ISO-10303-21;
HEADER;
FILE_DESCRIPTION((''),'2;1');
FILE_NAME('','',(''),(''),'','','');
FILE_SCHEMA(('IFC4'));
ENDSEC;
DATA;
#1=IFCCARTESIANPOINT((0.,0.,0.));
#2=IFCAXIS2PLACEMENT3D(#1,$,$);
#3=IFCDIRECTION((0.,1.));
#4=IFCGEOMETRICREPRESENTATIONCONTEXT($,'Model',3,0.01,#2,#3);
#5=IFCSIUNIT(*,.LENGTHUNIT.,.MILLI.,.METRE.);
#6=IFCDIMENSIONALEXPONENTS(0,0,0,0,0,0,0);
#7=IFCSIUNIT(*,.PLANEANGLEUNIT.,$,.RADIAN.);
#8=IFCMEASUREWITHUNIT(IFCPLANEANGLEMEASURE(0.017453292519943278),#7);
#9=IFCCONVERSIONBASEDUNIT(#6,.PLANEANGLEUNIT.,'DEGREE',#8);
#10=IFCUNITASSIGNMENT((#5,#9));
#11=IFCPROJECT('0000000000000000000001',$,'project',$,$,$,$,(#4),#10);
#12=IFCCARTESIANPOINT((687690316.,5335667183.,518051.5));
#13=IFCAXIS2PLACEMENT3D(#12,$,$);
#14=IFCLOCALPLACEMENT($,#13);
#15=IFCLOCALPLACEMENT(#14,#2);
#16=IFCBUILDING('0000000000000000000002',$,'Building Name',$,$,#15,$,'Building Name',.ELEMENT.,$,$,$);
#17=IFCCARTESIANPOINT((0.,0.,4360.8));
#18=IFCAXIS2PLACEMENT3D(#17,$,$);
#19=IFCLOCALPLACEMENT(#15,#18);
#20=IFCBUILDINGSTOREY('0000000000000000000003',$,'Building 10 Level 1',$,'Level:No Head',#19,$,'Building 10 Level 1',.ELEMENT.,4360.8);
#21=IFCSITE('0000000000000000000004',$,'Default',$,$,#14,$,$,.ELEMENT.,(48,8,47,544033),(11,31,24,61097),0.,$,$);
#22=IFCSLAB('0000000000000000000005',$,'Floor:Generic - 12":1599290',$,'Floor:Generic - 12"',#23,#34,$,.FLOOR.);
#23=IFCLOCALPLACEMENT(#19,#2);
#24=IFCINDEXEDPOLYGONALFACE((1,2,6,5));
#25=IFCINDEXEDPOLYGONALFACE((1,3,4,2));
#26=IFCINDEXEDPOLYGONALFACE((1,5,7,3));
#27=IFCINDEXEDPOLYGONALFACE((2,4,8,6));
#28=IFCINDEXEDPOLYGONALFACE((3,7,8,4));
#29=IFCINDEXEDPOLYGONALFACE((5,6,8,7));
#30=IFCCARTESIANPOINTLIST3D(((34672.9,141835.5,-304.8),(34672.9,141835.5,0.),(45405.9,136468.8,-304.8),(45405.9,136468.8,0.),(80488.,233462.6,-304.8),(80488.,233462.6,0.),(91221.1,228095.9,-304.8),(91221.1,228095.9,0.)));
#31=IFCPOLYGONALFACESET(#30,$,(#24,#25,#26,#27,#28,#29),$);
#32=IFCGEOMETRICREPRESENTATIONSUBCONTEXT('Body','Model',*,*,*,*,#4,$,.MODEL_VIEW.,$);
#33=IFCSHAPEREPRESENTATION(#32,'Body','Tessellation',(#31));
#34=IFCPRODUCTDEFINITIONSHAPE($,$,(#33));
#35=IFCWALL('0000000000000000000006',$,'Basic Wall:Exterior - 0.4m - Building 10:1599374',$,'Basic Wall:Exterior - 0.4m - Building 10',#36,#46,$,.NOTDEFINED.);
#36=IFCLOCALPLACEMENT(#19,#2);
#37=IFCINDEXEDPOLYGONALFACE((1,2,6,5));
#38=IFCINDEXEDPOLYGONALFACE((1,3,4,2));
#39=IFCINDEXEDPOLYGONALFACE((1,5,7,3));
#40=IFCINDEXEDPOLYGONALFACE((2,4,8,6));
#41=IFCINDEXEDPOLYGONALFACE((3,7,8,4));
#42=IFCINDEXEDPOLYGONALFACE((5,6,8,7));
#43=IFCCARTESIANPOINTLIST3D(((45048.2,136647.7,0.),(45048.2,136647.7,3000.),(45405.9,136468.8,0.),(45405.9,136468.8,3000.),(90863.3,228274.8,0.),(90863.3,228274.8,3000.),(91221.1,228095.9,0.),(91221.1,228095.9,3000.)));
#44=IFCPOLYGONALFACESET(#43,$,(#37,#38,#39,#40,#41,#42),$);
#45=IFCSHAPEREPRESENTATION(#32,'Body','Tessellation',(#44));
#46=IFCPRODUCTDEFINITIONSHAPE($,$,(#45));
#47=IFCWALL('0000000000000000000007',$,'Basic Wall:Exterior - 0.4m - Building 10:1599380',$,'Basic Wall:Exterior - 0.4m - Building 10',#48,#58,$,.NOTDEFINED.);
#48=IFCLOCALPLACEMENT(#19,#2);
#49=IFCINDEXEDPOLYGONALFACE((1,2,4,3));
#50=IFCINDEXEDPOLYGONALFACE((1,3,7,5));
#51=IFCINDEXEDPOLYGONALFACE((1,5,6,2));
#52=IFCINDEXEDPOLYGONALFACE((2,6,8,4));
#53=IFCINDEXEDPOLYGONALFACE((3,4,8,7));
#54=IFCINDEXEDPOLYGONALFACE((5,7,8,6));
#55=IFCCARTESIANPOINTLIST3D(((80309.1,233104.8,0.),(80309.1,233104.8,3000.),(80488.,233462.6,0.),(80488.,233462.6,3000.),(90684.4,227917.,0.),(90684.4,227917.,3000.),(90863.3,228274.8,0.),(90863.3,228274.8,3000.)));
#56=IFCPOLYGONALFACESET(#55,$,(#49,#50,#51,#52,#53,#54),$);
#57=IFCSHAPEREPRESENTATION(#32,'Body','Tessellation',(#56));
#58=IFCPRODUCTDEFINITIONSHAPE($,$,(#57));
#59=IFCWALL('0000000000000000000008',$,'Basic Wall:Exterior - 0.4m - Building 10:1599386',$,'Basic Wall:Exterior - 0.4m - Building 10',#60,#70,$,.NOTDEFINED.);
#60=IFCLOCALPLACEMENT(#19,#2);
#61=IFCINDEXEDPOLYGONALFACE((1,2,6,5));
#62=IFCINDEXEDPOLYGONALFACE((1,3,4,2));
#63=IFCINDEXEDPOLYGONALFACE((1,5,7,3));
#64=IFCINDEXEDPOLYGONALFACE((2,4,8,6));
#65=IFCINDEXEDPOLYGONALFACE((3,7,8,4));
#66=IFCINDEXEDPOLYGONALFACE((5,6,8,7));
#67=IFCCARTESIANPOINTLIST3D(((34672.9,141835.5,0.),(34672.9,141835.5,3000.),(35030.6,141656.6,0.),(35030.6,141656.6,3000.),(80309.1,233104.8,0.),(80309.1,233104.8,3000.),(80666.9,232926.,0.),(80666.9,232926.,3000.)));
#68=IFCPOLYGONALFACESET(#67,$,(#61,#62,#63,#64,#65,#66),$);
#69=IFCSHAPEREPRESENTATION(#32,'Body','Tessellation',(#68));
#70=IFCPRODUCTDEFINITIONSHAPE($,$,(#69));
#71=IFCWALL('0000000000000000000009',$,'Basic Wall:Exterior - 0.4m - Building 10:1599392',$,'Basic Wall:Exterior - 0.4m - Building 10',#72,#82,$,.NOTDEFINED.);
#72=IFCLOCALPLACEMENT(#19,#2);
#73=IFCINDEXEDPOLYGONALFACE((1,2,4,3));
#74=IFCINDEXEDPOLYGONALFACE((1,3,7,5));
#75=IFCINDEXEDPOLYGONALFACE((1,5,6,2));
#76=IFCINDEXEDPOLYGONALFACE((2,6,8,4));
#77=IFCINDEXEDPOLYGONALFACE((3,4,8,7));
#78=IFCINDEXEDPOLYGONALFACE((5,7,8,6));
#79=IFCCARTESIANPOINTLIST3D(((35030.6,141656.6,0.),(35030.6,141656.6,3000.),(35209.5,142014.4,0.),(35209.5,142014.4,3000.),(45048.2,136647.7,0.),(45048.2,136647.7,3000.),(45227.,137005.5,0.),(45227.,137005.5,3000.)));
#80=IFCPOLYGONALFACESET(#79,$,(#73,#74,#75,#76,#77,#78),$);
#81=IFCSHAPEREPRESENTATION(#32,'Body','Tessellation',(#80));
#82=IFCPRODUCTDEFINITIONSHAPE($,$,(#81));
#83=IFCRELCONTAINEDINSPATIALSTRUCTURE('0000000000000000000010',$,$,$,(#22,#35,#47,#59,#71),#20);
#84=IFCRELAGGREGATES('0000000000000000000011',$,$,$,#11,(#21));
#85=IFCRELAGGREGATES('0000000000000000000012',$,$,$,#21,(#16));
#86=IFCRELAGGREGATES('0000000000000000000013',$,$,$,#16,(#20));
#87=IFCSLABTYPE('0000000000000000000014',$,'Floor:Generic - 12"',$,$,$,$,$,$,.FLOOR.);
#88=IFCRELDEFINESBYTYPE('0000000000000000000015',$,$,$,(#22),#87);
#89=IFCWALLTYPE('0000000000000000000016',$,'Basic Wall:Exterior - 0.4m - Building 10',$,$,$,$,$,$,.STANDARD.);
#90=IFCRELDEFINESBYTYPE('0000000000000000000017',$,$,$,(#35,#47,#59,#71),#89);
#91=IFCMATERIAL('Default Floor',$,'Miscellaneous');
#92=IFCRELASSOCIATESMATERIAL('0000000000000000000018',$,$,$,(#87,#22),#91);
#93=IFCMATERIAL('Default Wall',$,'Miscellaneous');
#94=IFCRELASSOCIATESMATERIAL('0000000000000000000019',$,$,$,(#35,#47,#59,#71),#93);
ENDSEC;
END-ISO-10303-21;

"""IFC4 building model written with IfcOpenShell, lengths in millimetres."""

from ifc_helpers import new_model, entity, si_unit, converted_unit, direction, frame, origin, place, context, subcontext, project, spatial, indexed_curve, outline, extrude, material, type_object, element, save


model = new_model("IFC4")

# Units and contexts
model_context = context("Model", 3, precision=0.01, world=origin(), true_north=direction((0.0, 1.0)))
body_context = subcontext(model_context, "Body", "Model", "MODEL_VIEW")
ifc_project = project(units=[si_unit("LENGTHUNIT", "METRE", prefix="MILLI"), converted_unit("PLANEANGLEUNIT", "DEGREE", entity("IfcPlaneAngleMeasure", 0.017453292519943278), si_unit("PLANEANGLEUNIT", "RADIAN"), dimensions=[0, 0, 0, 0, 0, 0, 0])], contexts=[model_context])

# Site, building, storey
site_placement = place(None, frame((687690316.0, 5335667183.0, 518051.5)))
site = spatial("IfcSite", under=ifc_project, at=site_placement, Name="Default", CompositionType="ELEMENT", RefLatitude=(48, 8, 47, 544033), RefLongitude=(11, 31, 24, 61097), RefElevation=0.0)
building_placement = place(site_placement, origin())
building = spatial("IfcBuilding", under=site, at=building_placement, Name="Building Name", LongName="Building Name", CompositionType="ELEMENT")
storey_placement = place(building_placement, frame((0.0, 0.0, 4360.8)))
storey = spatial("IfcBuildingStorey", under=building, at=storey_placement, Name="Building 10 Level 1", ObjectType="Level:No Head", LongName="Building 10 Level 1", CompositionType="ELEMENT", Elevation=4360.8)

# Slab
ifc_material_1 = material(Name="Default Floor", Category="Miscellaneous")
slab_type = type_object("IfcSlabType", Name="Floor:Generic - 12\"", PredefinedType="FLOOR", material=ifc_material_1)
slab_placement = place(storey_placement, origin())
element("IfcSlab", 1, at=slab_placement, inside=storey, type_object=slab_type, material=ifc_material_1, Name="Floor:Generic - 12\":1599290", ObjectType="Floor:Generic - 12\"", PredefinedType="FLOOR", context=body_context, shape_type="SweptSolid", body=[
    extrude(outline(indexed_curve([(-51221.4, -6000.0), (51221.4, -6000.0), (51221.4, 6000.0), (-51221.4, 6000.0), (-51221.4, -6000.0)], self_intersect=False)), frame((62947.0, 184965.7, 0.0), z_axis=(0.0, 0.0, -1.0), x_axis=(-0.447226, -0.894421, 0.0)), (0.0, 0.0, 1.0), 304.8),
])

# Walls
ifc_material_2 = material(Name="Default Wall", Category="Miscellaneous")
wall_type = type_object("IfcWallType", Name="Basic Wall:Exterior - 0.4m - Building 10", PredefinedType="STANDARD")
wall_1_placement = place(storey_placement, frame((45227.0, 136558.3, 0.0), z_axis=(0.0, 0.0, 1.0), x_axis=(0.447226, 0.894421, 0.0)))
element("IfcWall", 2, at=wall_1_placement, inside=storey, type_object=wall_type, material=ifc_material_2, Name="Basic Wall:Exterior - 0.4m - Building 10:1599374", ObjectType="Basic Wall:Exterior - 0.4m - Building 10", PredefinedType="NOTDEFINED", context=body_context, shape_type="SweptSolid", body=[
    extrude(outline(indexed_curve([(102442.9, 200.0), (0.0, 200.0), (0.0, -200.0), (102442.9, -200.0), (102442.9, 200.0)], self_intersect=False)), origin(), (0.0, 0.0, 1.0), 3000.0),
])
wall_2_placement = place(storey_placement, frame((90773.8, 228095.9, 0.0), z_axis=(0.0, 0.0, 1.0), x_axis=(-0.894421, 0.447226, 0.0)))
element("IfcWall", 3, at=wall_2_placement, inside=storey, type_object=wall_type, material=ifc_material_2, Name="Basic Wall:Exterior - 0.4m - Building 10:1599380", ObjectType="Basic Wall:Exterior - 0.4m - Building 10", PredefinedType="NOTDEFINED", context=body_context, shape_type="SweptSolid", body=[
    extrude(outline(indexed_curve([(11600.0, 200.0), (0.0, 200.0), (0.0, -200.0), (11600.0, -200.0), (11600.0, 200.0)], self_intersect=False)), origin(), (0.0, 0.0, 1.0), 3000.0),
])
wall_3_placement = place(storey_placement, frame((80488.0, 233015.4, 0.0), z_axis=(0.0, 0.0, 1.0), x_axis=(-0.447226, -0.894421, 0.0)))
element("IfcWall", 4, at=wall_3_placement, inside=storey, type_object=wall_type, material=ifc_material_2, Name="Basic Wall:Exterior - 0.4m - Building 10:1599386", ObjectType="Basic Wall:Exterior - 0.4m - Building 10", PredefinedType="NOTDEFINED", context=body_context, shape_type="SweptSolid", body=[
    extrude(outline(indexed_curve([(102042.9, 200.0), (0.0, 200.0), (0.0, -200.0), (102042.9, -200.0), (102042.9, 200.0)], self_intersect=False)), origin(), (0.0, 0.0, 1.0), 3000.0),
])
wall_4_placement = place(storey_placement, frame((35120.1, 141835.5, 0.0), z_axis=(0.0, 0.0, 1.0), x_axis=(0.894421, -0.447226, 0.0)))
element("IfcWall", 5, at=wall_4_placement, inside=storey, type_object=wall_type, material=ifc_material_2, Name="Basic Wall:Exterior - 0.4m - Building 10:1599392", ObjectType="Basic Wall:Exterior - 0.4m - Building 10", PredefinedType="NOTDEFINED", context=body_context, shape_type="SweptSolid", body=[
    extrude(outline(indexed_curve([(11200.0, 200.0), (0.0, 200.0), (0.0, -200.0), (11200.0, -200.0), (11200.0, 200.0)], self_intersect=False)), origin(), (0.0, 0.0, 1.0), 3000.0),
])

save(model, "model.ifc")
